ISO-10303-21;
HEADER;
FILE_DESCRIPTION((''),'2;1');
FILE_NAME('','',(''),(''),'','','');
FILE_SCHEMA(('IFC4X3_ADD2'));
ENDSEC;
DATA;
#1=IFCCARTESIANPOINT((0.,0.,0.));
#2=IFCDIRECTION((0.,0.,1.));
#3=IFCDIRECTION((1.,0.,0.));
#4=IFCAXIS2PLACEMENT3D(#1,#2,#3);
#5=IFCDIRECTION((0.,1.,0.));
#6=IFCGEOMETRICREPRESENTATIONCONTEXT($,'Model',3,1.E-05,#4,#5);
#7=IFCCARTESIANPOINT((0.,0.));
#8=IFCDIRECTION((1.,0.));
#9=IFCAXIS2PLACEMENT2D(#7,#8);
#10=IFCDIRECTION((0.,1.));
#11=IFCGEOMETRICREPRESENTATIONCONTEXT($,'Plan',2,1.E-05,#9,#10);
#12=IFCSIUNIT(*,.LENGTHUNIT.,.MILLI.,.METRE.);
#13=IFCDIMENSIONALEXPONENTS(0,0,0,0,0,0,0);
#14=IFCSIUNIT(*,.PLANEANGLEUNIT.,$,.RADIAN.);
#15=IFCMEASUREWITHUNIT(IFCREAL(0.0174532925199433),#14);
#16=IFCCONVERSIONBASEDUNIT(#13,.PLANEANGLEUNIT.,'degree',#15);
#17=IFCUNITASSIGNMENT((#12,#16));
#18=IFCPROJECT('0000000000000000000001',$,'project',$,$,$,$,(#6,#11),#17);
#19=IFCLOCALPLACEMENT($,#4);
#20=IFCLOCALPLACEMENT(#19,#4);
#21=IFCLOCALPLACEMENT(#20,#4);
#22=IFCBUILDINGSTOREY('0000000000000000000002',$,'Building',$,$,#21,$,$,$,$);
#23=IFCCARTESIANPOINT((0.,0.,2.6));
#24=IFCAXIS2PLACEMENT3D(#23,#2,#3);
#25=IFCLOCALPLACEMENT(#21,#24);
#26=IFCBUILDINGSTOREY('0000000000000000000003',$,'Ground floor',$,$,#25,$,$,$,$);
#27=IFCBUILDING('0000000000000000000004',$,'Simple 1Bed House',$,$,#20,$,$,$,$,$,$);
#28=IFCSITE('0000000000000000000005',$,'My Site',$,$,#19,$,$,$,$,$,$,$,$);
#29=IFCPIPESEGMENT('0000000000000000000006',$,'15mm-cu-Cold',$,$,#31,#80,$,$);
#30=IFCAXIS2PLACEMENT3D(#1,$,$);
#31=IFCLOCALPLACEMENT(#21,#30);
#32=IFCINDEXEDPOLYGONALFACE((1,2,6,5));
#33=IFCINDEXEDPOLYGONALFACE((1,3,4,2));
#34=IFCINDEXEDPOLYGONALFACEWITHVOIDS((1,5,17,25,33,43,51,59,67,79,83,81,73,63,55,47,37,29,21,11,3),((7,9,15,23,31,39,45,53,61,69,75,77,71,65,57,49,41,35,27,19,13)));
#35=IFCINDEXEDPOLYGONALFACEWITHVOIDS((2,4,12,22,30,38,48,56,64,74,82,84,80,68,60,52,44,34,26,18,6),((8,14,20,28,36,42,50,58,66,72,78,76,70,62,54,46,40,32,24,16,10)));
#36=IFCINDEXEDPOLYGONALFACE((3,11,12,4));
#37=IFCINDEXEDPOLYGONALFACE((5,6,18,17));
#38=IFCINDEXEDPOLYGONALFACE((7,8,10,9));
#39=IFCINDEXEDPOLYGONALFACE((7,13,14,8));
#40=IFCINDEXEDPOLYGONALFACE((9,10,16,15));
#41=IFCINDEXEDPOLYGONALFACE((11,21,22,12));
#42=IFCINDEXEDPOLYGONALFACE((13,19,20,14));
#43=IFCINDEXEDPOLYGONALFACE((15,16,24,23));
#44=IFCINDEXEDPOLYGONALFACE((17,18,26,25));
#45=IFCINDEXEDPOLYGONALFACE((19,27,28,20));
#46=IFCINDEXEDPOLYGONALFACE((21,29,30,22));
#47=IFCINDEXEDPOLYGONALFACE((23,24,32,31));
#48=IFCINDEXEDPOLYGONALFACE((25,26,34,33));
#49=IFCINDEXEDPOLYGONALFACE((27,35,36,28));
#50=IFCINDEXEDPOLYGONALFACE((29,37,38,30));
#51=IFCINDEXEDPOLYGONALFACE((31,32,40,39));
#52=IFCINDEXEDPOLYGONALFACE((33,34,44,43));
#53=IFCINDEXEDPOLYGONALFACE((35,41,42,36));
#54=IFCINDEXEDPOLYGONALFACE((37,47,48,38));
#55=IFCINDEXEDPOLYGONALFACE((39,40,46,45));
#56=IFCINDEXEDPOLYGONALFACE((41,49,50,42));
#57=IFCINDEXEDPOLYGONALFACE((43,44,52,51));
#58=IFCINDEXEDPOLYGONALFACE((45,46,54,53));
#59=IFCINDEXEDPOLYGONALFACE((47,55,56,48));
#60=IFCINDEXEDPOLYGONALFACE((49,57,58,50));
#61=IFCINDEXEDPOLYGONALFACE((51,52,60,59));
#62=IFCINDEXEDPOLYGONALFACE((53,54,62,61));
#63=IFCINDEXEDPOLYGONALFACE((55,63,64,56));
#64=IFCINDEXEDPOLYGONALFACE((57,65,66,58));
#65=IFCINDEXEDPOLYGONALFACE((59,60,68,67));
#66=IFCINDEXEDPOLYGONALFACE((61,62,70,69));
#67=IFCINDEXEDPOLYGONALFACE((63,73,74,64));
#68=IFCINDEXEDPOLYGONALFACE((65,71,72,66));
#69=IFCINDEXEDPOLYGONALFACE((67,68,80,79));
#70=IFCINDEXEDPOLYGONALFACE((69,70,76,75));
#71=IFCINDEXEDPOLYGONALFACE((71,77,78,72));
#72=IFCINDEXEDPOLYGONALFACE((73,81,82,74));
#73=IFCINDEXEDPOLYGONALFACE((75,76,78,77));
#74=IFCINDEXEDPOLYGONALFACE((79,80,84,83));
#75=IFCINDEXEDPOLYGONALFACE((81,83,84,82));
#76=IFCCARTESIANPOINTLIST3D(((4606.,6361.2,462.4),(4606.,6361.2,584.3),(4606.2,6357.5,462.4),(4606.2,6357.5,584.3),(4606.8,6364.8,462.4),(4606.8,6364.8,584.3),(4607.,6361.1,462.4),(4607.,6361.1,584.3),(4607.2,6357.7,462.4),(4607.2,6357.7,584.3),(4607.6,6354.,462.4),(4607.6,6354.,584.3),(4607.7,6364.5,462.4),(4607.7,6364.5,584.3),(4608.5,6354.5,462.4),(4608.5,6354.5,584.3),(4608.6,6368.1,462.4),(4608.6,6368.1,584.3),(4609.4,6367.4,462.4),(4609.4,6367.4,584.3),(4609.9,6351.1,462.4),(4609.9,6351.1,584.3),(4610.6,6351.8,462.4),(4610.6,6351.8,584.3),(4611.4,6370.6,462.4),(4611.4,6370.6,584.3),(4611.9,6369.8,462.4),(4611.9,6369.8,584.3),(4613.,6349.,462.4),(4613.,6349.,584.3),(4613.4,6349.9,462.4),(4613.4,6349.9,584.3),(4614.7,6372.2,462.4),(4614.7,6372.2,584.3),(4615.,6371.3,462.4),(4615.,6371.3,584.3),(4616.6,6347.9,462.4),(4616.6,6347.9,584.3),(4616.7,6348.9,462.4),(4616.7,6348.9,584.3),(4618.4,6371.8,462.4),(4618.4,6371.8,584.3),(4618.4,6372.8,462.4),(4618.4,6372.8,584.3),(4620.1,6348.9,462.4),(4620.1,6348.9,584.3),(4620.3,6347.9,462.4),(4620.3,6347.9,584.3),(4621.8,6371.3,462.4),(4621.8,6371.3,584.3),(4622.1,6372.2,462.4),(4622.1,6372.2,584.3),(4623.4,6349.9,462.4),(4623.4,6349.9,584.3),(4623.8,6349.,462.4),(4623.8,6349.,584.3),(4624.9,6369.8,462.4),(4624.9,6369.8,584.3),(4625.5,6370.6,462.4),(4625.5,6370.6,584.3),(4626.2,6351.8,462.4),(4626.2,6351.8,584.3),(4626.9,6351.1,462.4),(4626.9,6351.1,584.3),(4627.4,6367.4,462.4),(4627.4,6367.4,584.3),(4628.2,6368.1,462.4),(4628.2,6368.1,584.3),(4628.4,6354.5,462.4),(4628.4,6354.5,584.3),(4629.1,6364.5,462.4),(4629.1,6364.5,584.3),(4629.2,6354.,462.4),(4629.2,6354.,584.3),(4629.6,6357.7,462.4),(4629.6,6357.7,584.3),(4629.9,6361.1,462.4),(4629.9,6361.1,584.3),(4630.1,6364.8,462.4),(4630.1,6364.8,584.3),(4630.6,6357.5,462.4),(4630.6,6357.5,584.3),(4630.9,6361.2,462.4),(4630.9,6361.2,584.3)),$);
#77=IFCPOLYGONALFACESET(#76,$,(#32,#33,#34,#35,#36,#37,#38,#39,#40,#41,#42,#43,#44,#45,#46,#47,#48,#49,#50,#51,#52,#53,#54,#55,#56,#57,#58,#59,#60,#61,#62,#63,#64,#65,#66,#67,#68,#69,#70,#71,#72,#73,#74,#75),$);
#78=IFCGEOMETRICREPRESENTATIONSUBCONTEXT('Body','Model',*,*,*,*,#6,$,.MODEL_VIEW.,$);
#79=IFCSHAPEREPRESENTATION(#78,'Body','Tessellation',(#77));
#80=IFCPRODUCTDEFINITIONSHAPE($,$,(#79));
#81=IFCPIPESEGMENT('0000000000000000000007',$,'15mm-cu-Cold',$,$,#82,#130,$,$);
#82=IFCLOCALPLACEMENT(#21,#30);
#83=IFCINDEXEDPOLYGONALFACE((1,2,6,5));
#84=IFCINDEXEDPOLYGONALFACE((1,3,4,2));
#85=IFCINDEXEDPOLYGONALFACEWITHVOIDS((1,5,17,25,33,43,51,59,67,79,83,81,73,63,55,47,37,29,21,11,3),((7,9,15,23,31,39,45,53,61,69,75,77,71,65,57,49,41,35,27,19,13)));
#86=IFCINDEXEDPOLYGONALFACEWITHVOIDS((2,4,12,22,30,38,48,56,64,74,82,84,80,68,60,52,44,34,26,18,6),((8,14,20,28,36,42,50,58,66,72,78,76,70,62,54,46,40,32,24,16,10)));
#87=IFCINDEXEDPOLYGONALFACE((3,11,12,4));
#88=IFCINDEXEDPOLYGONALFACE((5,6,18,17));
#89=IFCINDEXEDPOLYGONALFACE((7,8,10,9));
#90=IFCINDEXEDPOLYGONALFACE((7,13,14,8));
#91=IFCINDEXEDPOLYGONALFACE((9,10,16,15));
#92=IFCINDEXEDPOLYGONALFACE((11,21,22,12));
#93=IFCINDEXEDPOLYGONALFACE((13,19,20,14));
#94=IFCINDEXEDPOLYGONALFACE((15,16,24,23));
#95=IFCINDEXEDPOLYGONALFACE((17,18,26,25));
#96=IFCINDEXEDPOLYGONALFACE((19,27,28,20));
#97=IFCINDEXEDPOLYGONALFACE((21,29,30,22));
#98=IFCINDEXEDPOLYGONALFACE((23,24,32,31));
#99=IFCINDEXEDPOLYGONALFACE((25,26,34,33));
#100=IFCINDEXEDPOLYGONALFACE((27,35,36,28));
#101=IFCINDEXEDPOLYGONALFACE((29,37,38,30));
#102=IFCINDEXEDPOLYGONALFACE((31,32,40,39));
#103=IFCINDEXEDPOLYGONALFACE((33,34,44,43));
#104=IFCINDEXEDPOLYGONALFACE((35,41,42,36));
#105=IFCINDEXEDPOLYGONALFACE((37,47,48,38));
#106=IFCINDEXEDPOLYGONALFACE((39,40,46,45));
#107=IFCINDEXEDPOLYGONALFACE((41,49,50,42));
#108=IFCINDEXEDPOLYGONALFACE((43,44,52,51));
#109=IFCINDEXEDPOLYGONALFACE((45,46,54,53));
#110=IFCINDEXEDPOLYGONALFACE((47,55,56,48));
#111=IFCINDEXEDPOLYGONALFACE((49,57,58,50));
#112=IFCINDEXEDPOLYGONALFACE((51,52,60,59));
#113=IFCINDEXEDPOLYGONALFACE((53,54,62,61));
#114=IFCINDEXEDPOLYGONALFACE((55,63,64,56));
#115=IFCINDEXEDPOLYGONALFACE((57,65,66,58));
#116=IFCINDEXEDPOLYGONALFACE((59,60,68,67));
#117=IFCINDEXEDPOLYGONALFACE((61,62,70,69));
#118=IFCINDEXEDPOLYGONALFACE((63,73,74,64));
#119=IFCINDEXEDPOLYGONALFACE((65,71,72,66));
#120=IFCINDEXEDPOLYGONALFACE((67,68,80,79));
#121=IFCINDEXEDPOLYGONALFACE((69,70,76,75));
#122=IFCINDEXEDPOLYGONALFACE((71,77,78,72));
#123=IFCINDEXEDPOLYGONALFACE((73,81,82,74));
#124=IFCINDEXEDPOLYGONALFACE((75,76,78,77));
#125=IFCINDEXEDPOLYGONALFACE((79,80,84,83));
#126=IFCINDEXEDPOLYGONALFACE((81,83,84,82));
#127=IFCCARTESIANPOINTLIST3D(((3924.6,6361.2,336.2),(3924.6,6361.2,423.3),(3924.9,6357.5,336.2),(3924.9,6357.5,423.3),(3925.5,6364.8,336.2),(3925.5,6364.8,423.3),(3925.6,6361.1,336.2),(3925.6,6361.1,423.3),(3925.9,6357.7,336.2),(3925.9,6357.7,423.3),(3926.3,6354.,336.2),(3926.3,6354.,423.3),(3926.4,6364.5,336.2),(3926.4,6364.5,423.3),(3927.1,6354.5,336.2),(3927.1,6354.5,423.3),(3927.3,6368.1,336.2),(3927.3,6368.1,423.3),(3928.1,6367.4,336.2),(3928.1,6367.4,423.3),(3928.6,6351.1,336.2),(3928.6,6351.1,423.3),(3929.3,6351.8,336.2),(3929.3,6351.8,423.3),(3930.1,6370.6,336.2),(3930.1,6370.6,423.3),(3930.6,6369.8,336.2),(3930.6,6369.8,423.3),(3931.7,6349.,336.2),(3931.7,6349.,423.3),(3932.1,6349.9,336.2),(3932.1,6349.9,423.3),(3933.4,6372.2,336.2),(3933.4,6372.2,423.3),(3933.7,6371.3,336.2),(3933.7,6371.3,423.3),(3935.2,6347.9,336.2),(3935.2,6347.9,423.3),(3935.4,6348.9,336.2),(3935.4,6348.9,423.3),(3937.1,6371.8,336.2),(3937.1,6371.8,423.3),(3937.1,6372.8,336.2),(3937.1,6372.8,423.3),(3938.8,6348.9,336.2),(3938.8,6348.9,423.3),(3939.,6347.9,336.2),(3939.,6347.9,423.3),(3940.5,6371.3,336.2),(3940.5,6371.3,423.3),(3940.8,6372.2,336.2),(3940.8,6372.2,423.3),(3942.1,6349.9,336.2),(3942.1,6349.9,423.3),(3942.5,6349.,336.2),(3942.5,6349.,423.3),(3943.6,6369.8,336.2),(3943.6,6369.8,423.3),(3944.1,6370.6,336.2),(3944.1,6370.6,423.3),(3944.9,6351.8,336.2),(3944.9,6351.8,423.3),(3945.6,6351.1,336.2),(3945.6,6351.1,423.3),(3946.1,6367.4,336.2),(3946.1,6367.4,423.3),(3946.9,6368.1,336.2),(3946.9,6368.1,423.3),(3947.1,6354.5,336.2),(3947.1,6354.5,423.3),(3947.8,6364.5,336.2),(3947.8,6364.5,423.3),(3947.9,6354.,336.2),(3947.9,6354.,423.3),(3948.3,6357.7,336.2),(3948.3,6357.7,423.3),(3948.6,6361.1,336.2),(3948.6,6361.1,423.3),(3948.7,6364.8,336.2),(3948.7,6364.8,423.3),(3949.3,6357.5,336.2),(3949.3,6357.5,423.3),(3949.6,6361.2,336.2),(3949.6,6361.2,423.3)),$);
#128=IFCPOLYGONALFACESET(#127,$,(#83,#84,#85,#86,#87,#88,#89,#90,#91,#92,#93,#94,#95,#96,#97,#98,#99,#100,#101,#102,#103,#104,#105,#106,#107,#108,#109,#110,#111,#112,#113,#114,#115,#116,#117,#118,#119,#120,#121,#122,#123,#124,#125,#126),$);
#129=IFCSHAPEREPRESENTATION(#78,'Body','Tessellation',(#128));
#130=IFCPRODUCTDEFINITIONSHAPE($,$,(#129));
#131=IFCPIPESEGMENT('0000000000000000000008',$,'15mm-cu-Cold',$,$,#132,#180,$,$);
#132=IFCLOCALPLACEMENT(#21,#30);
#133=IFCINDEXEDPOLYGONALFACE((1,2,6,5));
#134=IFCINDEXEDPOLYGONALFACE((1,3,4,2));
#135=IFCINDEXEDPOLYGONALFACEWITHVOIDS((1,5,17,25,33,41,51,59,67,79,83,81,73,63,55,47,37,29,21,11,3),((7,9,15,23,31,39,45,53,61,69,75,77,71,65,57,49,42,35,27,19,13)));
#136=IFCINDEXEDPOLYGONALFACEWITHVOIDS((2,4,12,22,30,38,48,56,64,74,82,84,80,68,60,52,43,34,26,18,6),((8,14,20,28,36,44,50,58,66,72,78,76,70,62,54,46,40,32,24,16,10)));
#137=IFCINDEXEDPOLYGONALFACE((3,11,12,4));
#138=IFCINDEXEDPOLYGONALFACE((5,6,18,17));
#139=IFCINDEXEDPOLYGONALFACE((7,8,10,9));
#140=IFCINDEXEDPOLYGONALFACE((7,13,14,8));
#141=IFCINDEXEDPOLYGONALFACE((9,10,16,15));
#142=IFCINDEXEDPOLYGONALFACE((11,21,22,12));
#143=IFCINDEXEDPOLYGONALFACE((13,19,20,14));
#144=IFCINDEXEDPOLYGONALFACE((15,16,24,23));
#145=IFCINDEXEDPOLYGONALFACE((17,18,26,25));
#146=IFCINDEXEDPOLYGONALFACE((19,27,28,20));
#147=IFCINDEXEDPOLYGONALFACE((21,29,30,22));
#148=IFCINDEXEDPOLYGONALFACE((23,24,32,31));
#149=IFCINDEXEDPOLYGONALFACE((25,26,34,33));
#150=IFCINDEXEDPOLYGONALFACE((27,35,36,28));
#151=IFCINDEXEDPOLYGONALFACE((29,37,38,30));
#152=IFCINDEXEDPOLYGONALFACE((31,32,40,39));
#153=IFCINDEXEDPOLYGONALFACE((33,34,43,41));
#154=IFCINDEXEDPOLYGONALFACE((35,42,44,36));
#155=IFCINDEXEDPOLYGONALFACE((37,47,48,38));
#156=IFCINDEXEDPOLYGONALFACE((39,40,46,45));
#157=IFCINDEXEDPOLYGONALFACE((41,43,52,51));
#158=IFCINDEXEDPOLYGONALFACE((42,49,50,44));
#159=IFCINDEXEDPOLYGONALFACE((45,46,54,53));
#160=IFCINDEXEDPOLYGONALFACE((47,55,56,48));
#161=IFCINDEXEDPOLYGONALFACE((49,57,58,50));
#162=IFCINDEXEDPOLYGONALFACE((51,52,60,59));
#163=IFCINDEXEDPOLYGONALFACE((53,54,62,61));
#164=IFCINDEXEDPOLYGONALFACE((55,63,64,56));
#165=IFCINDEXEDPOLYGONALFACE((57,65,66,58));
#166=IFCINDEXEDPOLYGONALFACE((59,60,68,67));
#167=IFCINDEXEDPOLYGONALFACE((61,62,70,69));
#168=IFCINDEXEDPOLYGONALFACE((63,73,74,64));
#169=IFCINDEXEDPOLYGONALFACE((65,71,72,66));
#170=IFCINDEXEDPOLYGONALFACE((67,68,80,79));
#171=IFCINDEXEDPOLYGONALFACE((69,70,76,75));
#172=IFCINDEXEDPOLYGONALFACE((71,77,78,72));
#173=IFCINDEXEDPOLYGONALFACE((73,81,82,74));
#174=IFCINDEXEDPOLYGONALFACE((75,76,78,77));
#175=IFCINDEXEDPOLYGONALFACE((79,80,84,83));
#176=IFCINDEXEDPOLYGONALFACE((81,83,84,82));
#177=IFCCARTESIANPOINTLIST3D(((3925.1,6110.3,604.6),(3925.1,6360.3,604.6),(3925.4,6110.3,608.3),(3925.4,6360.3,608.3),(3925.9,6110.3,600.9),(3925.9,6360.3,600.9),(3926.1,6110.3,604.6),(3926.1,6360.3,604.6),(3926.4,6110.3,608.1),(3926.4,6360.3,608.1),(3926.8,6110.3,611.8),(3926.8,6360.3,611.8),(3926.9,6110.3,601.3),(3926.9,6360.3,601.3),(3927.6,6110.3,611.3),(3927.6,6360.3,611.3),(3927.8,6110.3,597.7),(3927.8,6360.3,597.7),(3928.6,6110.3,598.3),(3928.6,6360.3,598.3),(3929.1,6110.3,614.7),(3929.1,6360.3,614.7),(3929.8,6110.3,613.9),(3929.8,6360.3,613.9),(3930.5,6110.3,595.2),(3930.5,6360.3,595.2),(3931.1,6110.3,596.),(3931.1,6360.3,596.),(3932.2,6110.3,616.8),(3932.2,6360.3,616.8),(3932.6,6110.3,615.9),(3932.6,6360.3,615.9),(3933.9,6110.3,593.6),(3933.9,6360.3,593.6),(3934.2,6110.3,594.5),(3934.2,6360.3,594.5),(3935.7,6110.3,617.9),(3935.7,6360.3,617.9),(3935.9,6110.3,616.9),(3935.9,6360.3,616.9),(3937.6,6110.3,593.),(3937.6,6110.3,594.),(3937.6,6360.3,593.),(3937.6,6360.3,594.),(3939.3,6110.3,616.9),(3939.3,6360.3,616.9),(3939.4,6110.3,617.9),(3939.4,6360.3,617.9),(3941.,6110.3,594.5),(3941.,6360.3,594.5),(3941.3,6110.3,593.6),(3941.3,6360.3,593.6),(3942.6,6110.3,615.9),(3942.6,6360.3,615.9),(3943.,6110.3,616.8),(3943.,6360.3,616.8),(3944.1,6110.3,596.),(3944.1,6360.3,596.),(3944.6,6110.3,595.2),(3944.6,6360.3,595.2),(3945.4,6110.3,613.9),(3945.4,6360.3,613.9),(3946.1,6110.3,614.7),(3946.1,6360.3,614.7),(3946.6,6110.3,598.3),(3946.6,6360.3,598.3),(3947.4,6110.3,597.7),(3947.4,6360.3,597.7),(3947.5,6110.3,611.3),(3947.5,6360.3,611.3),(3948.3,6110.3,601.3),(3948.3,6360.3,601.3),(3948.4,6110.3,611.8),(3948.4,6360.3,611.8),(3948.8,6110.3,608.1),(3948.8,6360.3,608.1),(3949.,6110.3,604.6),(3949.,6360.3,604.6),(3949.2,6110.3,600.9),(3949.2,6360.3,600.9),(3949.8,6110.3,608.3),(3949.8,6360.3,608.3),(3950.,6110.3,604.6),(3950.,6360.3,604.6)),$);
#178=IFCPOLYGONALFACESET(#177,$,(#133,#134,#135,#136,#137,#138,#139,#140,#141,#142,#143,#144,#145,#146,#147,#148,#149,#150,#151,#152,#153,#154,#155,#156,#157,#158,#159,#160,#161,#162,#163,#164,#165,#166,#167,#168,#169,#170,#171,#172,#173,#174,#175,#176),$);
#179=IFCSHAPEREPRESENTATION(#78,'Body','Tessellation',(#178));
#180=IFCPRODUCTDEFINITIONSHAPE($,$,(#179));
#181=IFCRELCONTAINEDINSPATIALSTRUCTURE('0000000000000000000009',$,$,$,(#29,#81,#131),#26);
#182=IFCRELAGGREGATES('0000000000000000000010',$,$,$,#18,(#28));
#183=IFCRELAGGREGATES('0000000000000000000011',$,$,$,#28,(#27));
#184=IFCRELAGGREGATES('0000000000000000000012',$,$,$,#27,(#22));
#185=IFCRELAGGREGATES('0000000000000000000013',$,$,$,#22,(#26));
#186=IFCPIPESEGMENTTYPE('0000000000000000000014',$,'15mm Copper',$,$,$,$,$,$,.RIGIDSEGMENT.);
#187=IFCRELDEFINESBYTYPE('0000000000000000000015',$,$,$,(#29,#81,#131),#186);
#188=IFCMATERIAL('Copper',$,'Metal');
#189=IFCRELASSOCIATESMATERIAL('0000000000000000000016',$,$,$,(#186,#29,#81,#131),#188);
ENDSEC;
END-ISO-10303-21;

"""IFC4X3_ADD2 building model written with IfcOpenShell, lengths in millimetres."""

from ifc_helpers import new_model, entity, si_unit, converted_unit, direction, frame, origin_with_axes, origin_2d_with_axis, place, context, subcontext, project, spatial, hollow_circle, extrude, material, material_profile, profile_set, profile_usage, type_object, element, save


model = new_model("IFC4X3_ADD2")

# Units and contexts
model_context = context("Model", 3, precision=1e-05, world=origin_with_axes(), true_north=direction((0.0, 1.0, 0.0)))
plan_context = context("Plan", 2, precision=1e-05, world=origin_2d_with_axis(), true_north=direction((0.0, 1.0)))
body_context_1 = subcontext(model_context, "Body", "Model", "MODEL_VIEW")
ifc_project = project(units=[si_unit("LENGTHUNIT", "METRE", prefix="MILLI"), converted_unit("PLANEANGLEUNIT", "degree", entity("IfcReal", 0.0174532925199433), si_unit("PLANEANGLEUNIT", "RADIAN"), dimensions=[0, 0, 0, 0, 0, 0, 0])], contexts=[model_context, plan_context])

# Site, building, storeys
site_placement = place(None, origin_with_axes())
site = spatial("IfcSite", under=ifc_project, at=site_placement, Name="My Site")
building_placement = place(site_placement, origin_with_axes())
building = spatial("IfcBuilding", under=site, at=building_placement, Name="Simple 1Bed House")
storey_1_placement = place(building_placement, origin_with_axes())
storey_1 = spatial("IfcBuildingStorey", under=building, at=storey_1_placement, Name="Building")
storey_2_placement = place(storey_1_placement, frame((0.0, 0.0, 2.6), z_axis=(0.0, 0.0, 1.0), x_axis=(1.0, 0.0, 0.0)))
storey_2 = spatial("IfcBuildingStorey", under=storey_1, at=storey_2_placement, Name="Ground floor")

# Pipe segments
ifc_material_1 = material(Name="Copper", Category="Metal")
ifc_material_profile = material_profile(ifc_material_1, hollow_circle(Radius=12.5, WallThickness=1.0))
ifc_profile_set = profile_set([ifc_material_profile])
pipe_segment_type = type_object("IfcPipeSegmentType", Name="15mm Copper", PredefinedType="RIGIDSEGMENT", material=ifc_profile_set)
ifc_profile_usage_1 = profile_usage(ifc_profile_set, cardinal=5)
pipe_segment_1_placement = place(storey_2_placement, frame((4618.4, 6360.3, 581.7), z_axis=(0.0, 0.0, -1.0), x_axis=(0.0, 1.0, 0.0)))
element("IfcPipeSegment", 1, at=pipe_segment_1_placement, inside=storey_2, type_object=pipe_segment_type, material=ifc_profile_usage_1, Name="15mm-cu-Cold", context=body_context_1, shape_type="SweptSolid", body=[
    extrude(hollow_circle(Radius=12.5, WallThickness=1.0), origin_with_axes(), (0.0, 0.0, 1.0), 121.9),
])
ifc_profile_usage_2 = profile_usage(ifc_profile_set, cardinal=5)
pipe_segment_2_placement = place(storey_2_placement, frame((3937.1, 6360.3, 420.7), z_axis=(0.0, 0.0, -1.0), x_axis=(0.0, 1.0, 0.0)))
element("IfcPipeSegment", 2, at=pipe_segment_2_placement, inside=storey_2, type_object=pipe_segment_type, material=ifc_profile_usage_2, Name="15mm-cu-Cold", context=body_context_1, shape_type="SweptSolid", body=[
    extrude(hollow_circle(Radius=12.5, WallThickness=1.0), origin_with_axes(), (0.0, 0.0, 1.0), 87.1),
])
ifc_profile_usage_3 = profile_usage(ifc_profile_set, cardinal=5)
pipe_segment_3_placement = place(storey_2_placement, frame((3937.6, 6360.3, 602.9), z_axis=(0.0, -1.0, 0.0), x_axis=(0.0, 0.0, -1.0)))
element("IfcPipeSegment", 3, at=pipe_segment_3_placement, inside=storey_2, type_object=pipe_segment_type, material=ifc_profile_usage_3, Name="15mm-cu-Cold", context=body_context_1, shape_type="SweptSolid", body=[
    extrude(hollow_circle(Radius=12.5, WallThickness=1.0), origin_with_axes(), (0.0, 0.0, 1.0), 250.0),
])

save(model, "model.ifc")
